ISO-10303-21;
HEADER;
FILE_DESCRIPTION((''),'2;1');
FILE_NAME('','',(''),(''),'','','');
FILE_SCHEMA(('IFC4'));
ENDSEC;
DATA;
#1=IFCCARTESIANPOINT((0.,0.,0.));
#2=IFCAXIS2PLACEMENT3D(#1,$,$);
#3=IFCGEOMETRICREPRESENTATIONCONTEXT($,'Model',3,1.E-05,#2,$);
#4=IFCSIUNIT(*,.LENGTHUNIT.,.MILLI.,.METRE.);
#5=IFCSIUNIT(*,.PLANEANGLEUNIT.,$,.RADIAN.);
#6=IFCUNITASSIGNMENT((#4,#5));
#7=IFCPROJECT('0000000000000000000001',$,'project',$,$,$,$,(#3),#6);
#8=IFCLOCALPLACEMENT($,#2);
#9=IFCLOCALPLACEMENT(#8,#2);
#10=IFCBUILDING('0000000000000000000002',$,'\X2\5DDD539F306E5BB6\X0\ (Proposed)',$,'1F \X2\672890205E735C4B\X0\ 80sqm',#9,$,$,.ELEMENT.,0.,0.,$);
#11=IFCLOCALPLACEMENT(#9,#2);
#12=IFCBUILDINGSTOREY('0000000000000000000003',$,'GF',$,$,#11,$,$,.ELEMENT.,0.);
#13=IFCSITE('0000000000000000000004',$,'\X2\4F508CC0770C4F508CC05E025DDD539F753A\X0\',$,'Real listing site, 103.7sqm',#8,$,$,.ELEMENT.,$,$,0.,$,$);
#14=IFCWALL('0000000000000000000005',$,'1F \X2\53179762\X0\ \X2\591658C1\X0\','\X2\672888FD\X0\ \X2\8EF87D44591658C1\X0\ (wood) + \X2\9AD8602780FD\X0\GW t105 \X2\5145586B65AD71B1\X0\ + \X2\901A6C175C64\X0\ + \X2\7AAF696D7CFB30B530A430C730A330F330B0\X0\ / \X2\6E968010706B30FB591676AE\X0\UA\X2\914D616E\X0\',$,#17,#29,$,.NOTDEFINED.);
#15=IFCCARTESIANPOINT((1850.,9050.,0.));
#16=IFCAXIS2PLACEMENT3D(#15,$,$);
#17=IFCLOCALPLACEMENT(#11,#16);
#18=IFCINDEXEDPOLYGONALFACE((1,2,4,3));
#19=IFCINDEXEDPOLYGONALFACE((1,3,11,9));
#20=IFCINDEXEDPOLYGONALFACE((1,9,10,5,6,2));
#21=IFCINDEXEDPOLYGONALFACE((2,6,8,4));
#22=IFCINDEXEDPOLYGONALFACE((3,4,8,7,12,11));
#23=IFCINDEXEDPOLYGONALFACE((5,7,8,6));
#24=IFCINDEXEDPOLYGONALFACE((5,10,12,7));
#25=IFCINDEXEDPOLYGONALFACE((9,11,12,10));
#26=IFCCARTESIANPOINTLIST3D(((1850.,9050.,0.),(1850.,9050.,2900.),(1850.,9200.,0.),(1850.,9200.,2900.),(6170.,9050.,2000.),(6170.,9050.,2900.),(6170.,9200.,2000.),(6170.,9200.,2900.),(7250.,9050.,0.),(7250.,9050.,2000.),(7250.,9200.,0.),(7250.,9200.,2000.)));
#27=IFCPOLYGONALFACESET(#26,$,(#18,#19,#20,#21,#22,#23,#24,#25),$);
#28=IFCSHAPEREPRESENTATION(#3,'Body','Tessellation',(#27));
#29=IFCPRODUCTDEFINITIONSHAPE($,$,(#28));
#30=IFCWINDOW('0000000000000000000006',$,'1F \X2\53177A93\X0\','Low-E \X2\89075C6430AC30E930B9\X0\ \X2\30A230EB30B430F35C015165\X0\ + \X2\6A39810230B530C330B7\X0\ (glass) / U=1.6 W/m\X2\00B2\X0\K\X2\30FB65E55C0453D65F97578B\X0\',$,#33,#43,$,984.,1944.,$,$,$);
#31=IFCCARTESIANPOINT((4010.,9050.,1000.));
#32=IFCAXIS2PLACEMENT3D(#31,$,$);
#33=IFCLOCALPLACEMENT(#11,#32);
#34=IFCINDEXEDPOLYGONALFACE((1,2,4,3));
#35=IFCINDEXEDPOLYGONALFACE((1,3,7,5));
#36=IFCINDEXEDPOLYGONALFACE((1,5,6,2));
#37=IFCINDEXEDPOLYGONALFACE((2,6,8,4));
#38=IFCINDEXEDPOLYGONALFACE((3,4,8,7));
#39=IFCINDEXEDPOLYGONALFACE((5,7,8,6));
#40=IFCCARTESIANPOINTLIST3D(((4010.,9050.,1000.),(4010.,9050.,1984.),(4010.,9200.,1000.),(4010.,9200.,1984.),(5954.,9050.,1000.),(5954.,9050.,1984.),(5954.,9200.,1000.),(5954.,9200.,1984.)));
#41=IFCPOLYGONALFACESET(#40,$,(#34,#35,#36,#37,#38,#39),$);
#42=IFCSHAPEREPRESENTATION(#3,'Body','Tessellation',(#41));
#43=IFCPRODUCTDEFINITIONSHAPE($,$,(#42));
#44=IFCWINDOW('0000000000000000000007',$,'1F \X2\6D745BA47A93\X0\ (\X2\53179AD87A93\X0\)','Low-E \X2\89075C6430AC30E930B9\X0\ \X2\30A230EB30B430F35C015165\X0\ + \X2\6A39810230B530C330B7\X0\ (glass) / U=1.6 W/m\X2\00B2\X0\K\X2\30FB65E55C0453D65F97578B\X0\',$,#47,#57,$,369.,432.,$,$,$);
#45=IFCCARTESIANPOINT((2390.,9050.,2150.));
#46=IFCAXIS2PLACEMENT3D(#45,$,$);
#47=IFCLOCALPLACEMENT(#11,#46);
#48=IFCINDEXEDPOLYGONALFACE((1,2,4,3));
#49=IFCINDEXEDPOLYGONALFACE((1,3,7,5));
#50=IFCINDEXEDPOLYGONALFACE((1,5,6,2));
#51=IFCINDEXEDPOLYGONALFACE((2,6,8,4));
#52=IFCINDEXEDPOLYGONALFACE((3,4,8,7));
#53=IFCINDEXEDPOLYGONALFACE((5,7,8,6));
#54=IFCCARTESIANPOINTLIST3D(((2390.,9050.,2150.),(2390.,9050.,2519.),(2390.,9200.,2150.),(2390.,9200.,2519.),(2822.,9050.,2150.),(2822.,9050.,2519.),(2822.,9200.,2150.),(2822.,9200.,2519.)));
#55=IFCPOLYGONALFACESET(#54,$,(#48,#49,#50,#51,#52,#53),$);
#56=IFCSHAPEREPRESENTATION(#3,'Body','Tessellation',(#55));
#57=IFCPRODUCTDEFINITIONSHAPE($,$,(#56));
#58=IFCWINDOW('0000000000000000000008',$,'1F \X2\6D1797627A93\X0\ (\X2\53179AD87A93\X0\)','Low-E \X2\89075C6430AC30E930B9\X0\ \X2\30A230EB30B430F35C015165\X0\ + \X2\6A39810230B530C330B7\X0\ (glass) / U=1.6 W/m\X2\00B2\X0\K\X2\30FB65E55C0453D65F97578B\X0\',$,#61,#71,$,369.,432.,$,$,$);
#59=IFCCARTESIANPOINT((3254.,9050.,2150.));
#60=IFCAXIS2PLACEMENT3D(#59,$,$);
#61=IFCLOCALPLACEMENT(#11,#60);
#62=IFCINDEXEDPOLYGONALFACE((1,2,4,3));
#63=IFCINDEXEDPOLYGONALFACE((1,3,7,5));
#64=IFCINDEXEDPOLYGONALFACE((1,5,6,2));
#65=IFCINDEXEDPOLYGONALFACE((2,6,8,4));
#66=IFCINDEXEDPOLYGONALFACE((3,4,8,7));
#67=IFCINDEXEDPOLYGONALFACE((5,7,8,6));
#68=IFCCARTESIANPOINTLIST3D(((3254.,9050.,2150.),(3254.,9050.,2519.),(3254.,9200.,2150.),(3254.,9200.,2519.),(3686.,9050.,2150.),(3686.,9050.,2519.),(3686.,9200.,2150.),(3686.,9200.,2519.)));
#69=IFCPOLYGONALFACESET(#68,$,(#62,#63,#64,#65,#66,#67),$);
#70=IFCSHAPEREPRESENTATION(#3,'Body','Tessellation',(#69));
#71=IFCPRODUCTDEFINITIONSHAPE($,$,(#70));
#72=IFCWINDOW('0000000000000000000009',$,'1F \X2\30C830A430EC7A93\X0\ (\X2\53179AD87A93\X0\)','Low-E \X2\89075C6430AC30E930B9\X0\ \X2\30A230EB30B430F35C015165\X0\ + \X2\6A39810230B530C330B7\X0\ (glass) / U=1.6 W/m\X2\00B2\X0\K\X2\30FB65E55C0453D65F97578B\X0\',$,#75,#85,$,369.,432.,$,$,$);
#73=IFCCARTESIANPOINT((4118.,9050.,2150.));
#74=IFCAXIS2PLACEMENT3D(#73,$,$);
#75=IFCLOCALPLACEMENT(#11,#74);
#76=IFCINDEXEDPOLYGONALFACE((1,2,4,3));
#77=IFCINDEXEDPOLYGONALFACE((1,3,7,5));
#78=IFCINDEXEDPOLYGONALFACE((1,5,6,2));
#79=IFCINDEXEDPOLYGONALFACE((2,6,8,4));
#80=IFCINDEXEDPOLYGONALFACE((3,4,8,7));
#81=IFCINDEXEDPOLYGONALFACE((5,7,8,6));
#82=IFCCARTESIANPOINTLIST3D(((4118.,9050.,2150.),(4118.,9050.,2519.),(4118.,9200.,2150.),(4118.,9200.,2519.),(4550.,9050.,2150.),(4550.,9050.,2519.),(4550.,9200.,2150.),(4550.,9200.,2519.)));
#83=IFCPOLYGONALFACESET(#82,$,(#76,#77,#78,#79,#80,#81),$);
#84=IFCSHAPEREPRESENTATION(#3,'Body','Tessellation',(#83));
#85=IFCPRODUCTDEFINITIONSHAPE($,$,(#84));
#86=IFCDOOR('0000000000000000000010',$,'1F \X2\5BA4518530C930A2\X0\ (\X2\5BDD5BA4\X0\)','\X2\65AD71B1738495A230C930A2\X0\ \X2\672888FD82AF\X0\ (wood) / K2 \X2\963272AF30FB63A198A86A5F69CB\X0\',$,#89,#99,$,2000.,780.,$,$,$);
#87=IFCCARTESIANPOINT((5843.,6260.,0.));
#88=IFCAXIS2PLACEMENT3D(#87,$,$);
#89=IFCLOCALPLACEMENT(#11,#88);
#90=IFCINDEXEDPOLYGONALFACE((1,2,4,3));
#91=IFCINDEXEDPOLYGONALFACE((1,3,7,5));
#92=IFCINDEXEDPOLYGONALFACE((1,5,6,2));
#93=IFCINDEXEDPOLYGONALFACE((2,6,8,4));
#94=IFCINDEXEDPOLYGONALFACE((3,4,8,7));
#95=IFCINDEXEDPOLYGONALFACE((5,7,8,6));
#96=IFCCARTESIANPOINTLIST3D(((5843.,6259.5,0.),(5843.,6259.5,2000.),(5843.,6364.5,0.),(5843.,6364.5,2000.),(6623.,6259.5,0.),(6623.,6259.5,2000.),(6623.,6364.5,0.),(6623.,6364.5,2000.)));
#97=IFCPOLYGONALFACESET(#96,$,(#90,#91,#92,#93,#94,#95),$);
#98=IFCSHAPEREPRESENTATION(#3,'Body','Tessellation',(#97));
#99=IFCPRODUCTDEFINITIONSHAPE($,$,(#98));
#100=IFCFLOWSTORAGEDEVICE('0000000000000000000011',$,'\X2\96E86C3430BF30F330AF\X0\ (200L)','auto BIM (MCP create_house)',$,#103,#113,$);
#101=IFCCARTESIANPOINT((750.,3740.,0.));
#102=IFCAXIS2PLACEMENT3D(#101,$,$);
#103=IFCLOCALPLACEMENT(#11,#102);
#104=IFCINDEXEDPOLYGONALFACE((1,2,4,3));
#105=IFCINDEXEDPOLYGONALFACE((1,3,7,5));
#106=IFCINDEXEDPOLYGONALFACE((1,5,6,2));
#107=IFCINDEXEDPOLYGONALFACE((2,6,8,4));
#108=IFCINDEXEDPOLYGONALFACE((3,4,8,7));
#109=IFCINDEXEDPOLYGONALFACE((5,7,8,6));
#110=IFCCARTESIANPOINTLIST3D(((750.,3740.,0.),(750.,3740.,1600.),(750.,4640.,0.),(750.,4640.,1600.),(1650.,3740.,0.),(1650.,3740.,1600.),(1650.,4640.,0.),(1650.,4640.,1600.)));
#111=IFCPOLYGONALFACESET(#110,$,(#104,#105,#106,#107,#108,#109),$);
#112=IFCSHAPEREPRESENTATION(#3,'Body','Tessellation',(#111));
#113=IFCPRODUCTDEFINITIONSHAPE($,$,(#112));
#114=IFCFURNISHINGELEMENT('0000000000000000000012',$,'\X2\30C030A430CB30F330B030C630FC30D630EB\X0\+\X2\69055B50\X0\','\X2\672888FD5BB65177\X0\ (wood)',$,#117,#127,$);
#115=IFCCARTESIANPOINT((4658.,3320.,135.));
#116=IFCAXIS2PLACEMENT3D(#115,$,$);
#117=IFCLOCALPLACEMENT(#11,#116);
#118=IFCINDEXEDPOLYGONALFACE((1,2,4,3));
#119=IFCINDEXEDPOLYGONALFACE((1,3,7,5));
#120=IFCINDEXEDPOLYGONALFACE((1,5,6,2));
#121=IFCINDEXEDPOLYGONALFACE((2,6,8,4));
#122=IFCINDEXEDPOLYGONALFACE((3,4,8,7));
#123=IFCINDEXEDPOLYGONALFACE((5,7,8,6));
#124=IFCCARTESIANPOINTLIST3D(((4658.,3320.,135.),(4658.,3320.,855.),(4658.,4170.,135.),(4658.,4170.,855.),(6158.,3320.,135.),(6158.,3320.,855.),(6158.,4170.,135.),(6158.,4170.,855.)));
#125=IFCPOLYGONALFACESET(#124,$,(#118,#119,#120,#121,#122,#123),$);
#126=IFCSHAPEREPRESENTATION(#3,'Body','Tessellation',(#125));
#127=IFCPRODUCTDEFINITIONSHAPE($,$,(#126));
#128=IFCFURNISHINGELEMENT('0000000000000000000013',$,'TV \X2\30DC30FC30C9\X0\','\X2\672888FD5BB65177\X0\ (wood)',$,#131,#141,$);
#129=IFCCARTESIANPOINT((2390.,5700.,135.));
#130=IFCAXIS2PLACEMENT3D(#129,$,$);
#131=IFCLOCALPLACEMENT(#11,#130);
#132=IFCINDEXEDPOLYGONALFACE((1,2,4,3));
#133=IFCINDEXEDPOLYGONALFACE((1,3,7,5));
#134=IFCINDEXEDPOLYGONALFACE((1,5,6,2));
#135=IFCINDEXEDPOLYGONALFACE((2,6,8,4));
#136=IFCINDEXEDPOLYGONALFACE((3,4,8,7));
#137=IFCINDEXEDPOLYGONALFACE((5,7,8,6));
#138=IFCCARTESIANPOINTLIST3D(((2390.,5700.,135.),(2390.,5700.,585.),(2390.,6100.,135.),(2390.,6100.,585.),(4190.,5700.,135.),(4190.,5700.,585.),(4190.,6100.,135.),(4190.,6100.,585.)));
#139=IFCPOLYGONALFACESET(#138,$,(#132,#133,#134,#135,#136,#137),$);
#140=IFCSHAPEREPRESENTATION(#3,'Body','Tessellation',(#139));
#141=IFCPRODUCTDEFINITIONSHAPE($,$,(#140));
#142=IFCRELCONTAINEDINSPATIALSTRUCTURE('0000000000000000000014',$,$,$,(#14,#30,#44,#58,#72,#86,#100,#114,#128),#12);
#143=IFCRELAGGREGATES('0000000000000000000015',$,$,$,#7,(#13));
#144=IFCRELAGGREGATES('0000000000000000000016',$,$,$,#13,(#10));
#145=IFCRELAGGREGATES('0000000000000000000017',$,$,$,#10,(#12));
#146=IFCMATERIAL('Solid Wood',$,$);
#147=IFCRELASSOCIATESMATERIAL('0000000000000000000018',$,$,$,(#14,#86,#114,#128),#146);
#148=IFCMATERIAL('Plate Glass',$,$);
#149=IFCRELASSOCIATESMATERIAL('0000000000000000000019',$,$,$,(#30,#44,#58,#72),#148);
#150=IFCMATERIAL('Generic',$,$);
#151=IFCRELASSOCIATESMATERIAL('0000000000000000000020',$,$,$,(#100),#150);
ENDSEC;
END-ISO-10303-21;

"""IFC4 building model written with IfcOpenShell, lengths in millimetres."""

from ifc_helpers import new_model, si_unit, frame, frame_2d, origin, place, context, project, spatial, rectangle, extrude, material, element, fill, save


model = new_model("IFC4")

# Units and contexts
model_context = context("Model", 3, precision=1e-05, world=origin())
ifc_project = project(units=[si_unit("LENGTHUNIT", "METRE", prefix="MILLI"), si_unit("PLANEANGLEUNIT", "RADIAN")], contexts=[model_context])

# Site, building, storey
site_placement = place(None, origin())
site = spatial("IfcSite", under=ifc_project, at=site_placement, Name="佐賀県佐賀市川原町", ObjectType="Real listing site, 103.7sqm", CompositionType="ELEMENT", RefElevation=0.0)
building_placement = place(site_placement, origin())
building = spatial("IfcBuilding", under=site, at=building_placement, Name="川原の家 (Proposed)", ObjectType="1F 木造平屋 80sqm", CompositionType="ELEMENT", ElevationOfRefHeight=0.0, ElevationOfTerrain=0.0)
storey_placement = place(building_placement, origin())
storey = spatial("IfcBuildingStorey", under=building, at=storey_placement, Name="GF", CompositionType="ELEMENT", Elevation=0.0)

# Wall, openings, windows
ifc_material_1 = material(Name="Solid Wood")
wall_1_placement = place(storey_placement, frame((1850.0, 9050.0, 0.0)))
wall_1 = element("IfcWall", 1, at=wall_1_placement, inside=storey, material=ifc_material_1, Name="1F 北面 外壁", Description="木製 軸組外壁 (wood) + 高性能GW t105 充填断熱 + 通気層 + 窯業系サイディング / 準耐火・外皮UA配慮", PredefinedType="NOTDEFINED", context=model_context, shape_type="SweptSolid", body=[
    extrude(rectangle(XDim=5400.0, YDim=150.0, at=frame_2d((2700.0, 75.0))), frame((1850.0, 9050.0, 0.0)), (0.0, 0.0, 1.0), 2900.0),
])
opening_1_placement = place(storey_placement, frame((4010.0, 9050.0, 1000.0)))
opening_1 = element("IfcOpeningElement", 2, at=opening_1_placement, cuts=wall_1, PredefinedType="NOTDEFINED", context=model_context, shape_type="SweptSolid", body=[
    extrude(rectangle(XDim=1944.0, YDim=150.0, at=frame_2d((972.0, 75.0))), frame((4010.0, 9050.0, 1000.0)), (0.0, 0.0, 1.0), 984.0),
])
opening_2_placement = place(storey_placement, frame((2390.0, 9050.0, 2150.0)))
opening_2 = element("IfcOpeningElement", 3, at=opening_2_placement, cuts=wall_1, PredefinedType="NOTDEFINED", context=model_context, shape_type="SweptSolid", body=[
    extrude(rectangle(XDim=432.0, YDim=150.0, at=frame_2d((216.0, 75.0))), frame((2390.0, 9050.0, 2150.0)), (0.0, 0.0, 1.0), 369.0),
])
opening_3_placement = place(storey_placement, frame((3254.0, 9050.0, 2150.0)))
opening_3 = element("IfcOpeningElement", 4, at=opening_3_placement, cuts=wall_1, PredefinedType="NOTDEFINED", context=model_context, shape_type="SweptSolid", body=[
    extrude(rectangle(XDim=432.0, YDim=150.0, at=frame_2d((216.0, 75.0))), frame((3254.0, 9050.0, 2150.0)), (0.0, 0.0, 1.0), 369.0),
])
opening_4_placement = place(storey_placement, frame((4118.0, 9050.0, 2150.0)))
opening_4 = element("IfcOpeningElement", 5, at=opening_4_placement, cuts=wall_1, PredefinedType="NOTDEFINED", context=model_context, shape_type="SweptSolid", body=[
    extrude(rectangle(XDim=432.0, YDim=150.0, at=frame_2d((216.0, 75.0))), frame((4118.0, 9050.0, 2150.0)), (0.0, 0.0, 1.0), 369.0),
])
ifc_material_2 = material(Name="Plate Glass")
window_1_placement = place(storey_placement, frame((4010.0, 9050.0, 1000.0)))
window_1 = element("IfcWindow", 6, at=window_1_placement, inside=storey, material=ifc_material_2, Name="1F 北窓", Description="Low-E 複層ガラス アルゴン封入 + 樹脂サッシ (glass) / U=1.6 W/m²K・日射取得型", OverallHeight=984.0, OverallWidth=1944.0, context=model_context, shape_type="SweptSolid", body=[
    extrude(rectangle(XDim=1944.0, YDim=150.0, at=frame_2d((972.0, 75.0))), frame((4010.0, 9050.0, 1000.0)), (0.0, 0.0, 1.0), 984.0),
])
fill(opening_1, window_1)
window_2_placement = place(storey_placement, frame((2390.0, 9050.0, 2150.0)))
window_2 = element("IfcWindow", 7, at=window_2_placement, inside=storey, material=ifc_material_2, Name="1F 浴室窓 (北高窓)", Description="Low-E 複層ガラス アルゴン封入 + 樹脂サッシ (glass) / U=1.6 W/m²K・日射取得型", OverallHeight=369.0, OverallWidth=432.0, context=model_context, shape_type="SweptSolid", body=[
    extrude(rectangle(XDim=432.0, YDim=150.0, at=frame_2d((216.0, 75.0))), frame((2390.0, 9050.0, 2150.0)), (0.0, 0.0, 1.0), 369.0),
])
fill(opening_2, window_2)
window_3_placement = place(storey_placement, frame((3254.0, 9050.0, 2150.0)))
window_3 = element("IfcWindow", 8, at=window_3_placement, inside=storey, material=ifc_material_2, Name="1F 洗面窓 (北高窓)", Description="Low-E 複層ガラス アルゴン封入 + 樹脂サッシ (glass) / U=1.6 W/m²K・日射取得型", OverallHeight=369.0, OverallWidth=432.0, context=model_context, shape_type="SweptSolid", body=[
    extrude(rectangle(XDim=432.0, YDim=150.0, at=frame_2d((216.0, 75.0))), frame((3254.0, 9050.0, 2150.0)), (0.0, 0.0, 1.0), 369.0),
])
fill(opening_3, window_3)
window_4_placement = place(storey_placement, frame((4118.0, 9050.0, 2150.0)))
window_4 = element("IfcWindow", 9, at=window_4_placement, inside=storey, material=ifc_material_2, Name="1F トイレ窓 (北高窓)", Description="Low-E 複層ガラス アルゴン封入 + 樹脂サッシ (glass) / U=1.6 W/m²K・日射取得型", OverallHeight=369.0, OverallWidth=432.0, context=model_context, shape_type="SweptSolid", body=[
    extrude(rectangle(XDim=432.0, YDim=150.0, at=frame_2d((216.0, 75.0))), frame((4118.0, 9050.0, 2150.0)), (0.0, 0.0, 1.0), 369.0),
])
fill(opening_4, window_4)

# Door
door_1_placement = place(storey_placement, frame((5843.0, 6260.0, 0.0)))
element("IfcDoor", 10, at=door_1_placement, inside=storey, material=ifc_material_1, Name="1F 室内ドア (寝室)", Description="断熱玄関ドア 木製芯 (wood) / K2 防犯・採風機構", OverallHeight=2000.0, OverallWidth=780.0, context=model_context, shape_type="SweptSolid", body=[
    extrude(rectangle(XDim=780.0, YDim=105.0, at=frame_2d((390.0, 52.0))), frame((5843.0, 6260.0, 0.0)), (0.0, 0.0, 1.0), 2000.0),
])

# Flow storage device
ifc_material_3 = material(Name="Generic")
flow_storage_device_placement = place(storey_placement, frame((750.0, 3740.0, 0.0)))
element("IfcFlowStorageDevice", 11, at=flow_storage_device_placement, inside=storey, material=ifc_material_3, Name="雨水タンク (200L)", Description="auto BIM (MCP create_house)", context=model_context, shape_type="SweptSolid", body=[
    extrude(rectangle(XDim=900.0, YDim=900.0, at=frame_2d((450.0, 450.0))), frame((750.0, 3740.0, 0.0)), (0.0, 0.0, 1.0), 1600.0),
])

# Furnishing elements
furnishing_1_placement = place(storey_placement, frame((4658.0, 3320.0, 135.0)))
element("IfcFurnishingElement", 12, at=furnishing_1_placement, inside=storey, material=ifc_material_1, Name="ダイニングテーブル+椅子", Description="木製家具 (wood)", context=model_context, shape_type="SweptSolid", body=[
    extrude(rectangle(XDim=1500.0, YDim=850.0, at=frame_2d((750.0, 425.0))), frame((4658.0, 3320.0, 135.0)), (0.0, 0.0, 1.0), 720.0),
])
furnishing_2_placement = place(storey_placement, frame((2390.0, 5700.0, 135.0)))
element("IfcFurnishingElement", 13, at=furnishing_2_placement, inside=storey, material=ifc_material_1, Name="TV ボード", Description="木製家具 (wood)", context=model_context, shape_type="SweptSolid", body=[
    extrude(rectangle(XDim=1800.0, YDim=400.0, at=frame_2d((900.0, 200.0))), frame((2390.0, 5700.0, 135.0)), (0.0, 0.0, 1.0), 450.0),
])

save(model, "model.ifc")
